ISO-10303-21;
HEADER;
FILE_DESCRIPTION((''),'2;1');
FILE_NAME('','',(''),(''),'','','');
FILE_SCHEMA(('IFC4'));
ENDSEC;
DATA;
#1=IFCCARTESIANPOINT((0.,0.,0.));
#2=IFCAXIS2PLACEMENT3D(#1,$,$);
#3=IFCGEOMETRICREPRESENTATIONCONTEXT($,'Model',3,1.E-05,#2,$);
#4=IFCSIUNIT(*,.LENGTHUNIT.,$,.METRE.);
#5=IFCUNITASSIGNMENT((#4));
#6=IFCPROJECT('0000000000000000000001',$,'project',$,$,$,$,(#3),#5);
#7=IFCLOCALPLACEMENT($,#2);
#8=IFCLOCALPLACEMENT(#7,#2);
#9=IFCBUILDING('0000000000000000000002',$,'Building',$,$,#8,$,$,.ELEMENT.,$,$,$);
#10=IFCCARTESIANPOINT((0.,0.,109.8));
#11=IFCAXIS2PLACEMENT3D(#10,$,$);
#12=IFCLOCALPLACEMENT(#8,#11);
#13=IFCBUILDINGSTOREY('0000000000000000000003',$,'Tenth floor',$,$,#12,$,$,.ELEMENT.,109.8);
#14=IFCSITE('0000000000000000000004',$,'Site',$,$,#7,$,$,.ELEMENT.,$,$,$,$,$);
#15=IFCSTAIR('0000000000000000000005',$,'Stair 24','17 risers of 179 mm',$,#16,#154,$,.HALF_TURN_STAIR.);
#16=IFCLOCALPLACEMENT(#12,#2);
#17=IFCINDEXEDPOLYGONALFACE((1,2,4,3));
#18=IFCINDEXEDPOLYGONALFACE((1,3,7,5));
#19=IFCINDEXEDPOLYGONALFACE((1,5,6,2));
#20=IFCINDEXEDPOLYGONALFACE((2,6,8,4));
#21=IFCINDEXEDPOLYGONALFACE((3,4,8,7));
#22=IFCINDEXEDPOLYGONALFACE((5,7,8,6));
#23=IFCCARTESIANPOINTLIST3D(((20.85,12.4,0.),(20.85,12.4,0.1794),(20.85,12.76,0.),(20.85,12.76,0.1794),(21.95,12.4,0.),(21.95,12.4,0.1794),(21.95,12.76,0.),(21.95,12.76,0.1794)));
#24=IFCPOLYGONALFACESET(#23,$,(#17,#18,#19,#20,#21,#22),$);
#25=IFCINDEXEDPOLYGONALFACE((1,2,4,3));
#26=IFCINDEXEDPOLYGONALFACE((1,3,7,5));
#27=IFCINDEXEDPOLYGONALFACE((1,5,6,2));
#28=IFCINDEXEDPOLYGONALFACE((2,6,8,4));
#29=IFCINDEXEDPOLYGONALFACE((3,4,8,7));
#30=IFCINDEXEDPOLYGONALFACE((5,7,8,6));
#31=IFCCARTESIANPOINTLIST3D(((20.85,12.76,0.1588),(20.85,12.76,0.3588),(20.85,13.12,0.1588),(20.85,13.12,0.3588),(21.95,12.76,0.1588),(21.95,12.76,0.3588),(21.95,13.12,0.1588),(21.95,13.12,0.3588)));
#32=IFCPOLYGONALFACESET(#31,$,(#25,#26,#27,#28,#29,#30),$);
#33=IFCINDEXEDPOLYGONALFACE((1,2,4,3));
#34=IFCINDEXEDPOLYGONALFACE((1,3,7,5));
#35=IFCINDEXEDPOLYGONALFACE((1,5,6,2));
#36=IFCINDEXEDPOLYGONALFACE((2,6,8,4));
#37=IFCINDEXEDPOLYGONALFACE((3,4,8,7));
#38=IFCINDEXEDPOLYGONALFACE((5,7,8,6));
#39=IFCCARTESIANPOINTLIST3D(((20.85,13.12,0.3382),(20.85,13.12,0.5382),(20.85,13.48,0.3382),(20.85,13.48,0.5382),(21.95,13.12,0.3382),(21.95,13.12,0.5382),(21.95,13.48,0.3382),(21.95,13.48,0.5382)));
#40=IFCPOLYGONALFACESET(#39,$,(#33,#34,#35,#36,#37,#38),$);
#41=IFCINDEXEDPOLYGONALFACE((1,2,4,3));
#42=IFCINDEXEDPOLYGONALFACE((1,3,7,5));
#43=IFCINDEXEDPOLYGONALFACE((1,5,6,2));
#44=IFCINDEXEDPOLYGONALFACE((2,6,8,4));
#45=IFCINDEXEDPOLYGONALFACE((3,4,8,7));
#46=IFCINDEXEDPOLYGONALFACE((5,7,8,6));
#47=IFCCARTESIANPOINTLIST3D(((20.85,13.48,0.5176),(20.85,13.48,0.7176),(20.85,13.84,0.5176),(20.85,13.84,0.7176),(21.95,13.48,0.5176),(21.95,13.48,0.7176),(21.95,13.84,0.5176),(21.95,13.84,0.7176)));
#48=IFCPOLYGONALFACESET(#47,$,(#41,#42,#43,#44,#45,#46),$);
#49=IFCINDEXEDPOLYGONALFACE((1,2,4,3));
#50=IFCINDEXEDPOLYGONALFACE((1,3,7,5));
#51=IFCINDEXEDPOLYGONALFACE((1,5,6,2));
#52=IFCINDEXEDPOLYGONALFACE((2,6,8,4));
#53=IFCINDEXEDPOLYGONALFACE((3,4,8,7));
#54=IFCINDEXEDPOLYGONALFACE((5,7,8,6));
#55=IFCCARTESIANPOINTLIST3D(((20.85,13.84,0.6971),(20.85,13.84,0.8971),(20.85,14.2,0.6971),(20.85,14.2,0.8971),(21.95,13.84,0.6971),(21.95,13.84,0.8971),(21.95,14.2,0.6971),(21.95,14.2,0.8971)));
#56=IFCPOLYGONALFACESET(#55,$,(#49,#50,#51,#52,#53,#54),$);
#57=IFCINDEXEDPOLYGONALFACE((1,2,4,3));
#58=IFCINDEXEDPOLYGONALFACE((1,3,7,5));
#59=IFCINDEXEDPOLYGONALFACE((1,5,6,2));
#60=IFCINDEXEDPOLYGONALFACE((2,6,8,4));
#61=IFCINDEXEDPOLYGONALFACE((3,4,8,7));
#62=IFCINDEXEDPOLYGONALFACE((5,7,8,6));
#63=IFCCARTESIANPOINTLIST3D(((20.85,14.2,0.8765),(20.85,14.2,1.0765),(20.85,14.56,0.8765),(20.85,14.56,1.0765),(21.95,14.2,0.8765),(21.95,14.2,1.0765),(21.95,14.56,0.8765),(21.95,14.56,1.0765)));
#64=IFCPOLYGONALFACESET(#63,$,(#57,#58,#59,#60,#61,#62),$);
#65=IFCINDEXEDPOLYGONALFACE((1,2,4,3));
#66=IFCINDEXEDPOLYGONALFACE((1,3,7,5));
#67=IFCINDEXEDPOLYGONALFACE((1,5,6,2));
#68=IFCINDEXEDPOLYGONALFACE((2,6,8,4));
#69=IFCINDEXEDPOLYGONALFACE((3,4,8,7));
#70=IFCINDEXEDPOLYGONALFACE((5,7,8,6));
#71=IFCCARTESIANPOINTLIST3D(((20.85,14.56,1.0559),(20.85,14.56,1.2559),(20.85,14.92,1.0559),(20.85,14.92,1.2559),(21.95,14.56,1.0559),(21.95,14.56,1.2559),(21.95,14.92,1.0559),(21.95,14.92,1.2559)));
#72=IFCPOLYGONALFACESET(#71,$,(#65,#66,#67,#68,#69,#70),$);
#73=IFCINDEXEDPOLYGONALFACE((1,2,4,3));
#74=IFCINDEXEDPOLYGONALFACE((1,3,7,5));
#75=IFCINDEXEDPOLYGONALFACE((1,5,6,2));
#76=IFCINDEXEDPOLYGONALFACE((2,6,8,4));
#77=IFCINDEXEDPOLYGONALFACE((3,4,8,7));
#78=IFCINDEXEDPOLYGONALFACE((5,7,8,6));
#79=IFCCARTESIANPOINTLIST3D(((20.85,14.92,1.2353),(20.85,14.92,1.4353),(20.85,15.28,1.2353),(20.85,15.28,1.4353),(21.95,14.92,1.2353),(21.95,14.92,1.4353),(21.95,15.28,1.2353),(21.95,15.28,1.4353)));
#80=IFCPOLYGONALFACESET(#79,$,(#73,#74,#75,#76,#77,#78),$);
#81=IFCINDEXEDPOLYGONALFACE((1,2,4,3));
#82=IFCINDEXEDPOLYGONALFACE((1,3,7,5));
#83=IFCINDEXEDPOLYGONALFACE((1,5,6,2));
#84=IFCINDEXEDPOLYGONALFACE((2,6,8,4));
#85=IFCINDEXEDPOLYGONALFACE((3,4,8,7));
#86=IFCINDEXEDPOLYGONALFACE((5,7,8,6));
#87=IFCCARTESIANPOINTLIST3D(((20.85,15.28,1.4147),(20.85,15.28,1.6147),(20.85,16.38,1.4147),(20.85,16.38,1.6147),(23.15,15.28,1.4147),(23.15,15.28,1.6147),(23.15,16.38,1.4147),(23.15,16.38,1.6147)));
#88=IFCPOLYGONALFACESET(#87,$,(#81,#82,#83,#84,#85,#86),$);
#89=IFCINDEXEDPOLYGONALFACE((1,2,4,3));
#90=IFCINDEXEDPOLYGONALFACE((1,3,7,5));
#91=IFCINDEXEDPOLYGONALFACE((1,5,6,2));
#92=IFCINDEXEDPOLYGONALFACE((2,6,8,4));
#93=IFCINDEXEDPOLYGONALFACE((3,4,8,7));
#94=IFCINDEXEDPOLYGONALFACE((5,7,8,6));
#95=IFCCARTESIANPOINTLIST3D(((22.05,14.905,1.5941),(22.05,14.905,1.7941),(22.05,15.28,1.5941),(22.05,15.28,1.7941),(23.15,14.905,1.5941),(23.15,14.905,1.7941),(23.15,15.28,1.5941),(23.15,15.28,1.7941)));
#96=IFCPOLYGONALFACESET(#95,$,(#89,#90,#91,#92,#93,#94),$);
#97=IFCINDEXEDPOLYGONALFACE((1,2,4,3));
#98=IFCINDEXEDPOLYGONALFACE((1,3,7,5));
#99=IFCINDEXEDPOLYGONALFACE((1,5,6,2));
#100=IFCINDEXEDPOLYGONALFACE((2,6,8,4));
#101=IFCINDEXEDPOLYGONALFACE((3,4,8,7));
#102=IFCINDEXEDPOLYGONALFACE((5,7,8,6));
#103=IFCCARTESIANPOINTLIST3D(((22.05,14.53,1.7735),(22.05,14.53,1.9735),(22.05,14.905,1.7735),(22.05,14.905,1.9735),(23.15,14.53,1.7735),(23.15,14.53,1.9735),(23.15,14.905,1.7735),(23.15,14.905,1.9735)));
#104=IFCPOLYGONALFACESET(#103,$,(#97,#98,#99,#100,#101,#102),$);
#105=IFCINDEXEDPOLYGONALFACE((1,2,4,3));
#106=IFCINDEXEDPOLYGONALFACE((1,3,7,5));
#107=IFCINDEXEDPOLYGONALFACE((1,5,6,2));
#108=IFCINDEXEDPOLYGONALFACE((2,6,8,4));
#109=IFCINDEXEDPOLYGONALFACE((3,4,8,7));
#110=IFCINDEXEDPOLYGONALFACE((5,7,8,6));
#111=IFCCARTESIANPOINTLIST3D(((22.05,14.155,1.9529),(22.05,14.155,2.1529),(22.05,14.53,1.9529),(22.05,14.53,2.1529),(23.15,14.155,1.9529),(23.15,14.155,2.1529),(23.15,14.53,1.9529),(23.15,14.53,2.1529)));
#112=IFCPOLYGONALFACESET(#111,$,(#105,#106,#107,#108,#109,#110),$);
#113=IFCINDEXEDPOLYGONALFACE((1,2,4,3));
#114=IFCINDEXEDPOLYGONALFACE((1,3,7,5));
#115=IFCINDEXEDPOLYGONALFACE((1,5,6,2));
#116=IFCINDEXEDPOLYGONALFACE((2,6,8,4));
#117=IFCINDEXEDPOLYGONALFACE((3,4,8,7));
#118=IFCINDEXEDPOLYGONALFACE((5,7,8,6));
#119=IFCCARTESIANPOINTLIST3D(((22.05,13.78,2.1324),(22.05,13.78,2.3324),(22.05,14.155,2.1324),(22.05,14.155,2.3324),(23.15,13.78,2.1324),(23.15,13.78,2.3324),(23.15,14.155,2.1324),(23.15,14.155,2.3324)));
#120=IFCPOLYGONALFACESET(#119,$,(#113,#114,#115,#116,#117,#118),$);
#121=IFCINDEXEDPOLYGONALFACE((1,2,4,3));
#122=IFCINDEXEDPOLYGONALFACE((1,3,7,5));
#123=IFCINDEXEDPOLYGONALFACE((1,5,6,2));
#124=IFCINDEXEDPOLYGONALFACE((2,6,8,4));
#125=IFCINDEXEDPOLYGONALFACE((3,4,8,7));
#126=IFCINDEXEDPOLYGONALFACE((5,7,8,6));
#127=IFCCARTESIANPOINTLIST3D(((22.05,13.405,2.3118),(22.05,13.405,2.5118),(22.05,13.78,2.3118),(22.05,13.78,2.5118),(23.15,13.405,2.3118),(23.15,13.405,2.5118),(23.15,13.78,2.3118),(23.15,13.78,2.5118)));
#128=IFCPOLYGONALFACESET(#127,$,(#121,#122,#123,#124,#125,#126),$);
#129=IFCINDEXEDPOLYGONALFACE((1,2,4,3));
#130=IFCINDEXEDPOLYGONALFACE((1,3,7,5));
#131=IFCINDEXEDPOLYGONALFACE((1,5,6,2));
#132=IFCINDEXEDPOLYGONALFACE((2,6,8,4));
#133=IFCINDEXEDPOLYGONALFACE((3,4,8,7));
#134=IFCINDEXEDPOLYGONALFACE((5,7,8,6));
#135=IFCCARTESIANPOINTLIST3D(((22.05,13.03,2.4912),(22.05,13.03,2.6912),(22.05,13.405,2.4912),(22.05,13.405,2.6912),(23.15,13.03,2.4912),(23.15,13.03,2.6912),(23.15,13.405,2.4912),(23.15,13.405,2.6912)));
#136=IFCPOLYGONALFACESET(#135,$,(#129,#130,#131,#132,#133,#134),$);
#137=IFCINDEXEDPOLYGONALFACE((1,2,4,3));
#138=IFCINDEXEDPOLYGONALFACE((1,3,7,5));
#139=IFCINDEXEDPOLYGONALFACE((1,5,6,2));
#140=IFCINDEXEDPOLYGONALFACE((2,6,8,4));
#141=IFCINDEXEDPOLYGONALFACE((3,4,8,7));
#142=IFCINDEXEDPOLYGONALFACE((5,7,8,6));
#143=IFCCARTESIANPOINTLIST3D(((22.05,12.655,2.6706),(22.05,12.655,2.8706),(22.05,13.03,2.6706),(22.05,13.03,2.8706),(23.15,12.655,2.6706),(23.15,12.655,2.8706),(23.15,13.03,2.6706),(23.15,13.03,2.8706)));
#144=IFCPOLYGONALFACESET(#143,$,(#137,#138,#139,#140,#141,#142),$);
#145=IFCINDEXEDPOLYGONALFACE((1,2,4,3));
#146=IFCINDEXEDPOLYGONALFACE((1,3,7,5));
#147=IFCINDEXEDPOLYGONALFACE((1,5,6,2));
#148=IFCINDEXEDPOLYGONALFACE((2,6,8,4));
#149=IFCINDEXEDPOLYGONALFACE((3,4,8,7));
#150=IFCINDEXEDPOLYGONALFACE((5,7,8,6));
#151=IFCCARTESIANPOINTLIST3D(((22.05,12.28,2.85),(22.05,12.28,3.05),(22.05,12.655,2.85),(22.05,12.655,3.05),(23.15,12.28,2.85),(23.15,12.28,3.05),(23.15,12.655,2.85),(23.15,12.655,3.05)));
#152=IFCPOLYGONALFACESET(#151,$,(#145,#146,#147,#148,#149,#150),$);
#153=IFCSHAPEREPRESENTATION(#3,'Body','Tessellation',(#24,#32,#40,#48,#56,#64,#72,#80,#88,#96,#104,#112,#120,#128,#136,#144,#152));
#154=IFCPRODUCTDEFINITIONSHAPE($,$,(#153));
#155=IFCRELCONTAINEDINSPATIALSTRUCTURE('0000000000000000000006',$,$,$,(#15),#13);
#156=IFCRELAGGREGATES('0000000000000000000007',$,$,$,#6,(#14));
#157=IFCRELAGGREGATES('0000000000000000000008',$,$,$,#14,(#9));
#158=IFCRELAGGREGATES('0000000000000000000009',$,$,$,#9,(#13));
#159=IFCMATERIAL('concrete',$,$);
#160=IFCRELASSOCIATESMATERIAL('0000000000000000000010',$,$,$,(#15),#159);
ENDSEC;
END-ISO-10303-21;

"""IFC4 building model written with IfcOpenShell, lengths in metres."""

from ifc_helpers import new_model, si_unit, frame, origin, place, context, project, spatial, polyline, outline, extrude, material, element, save


model = new_model("IFC4")

# Units and contexts
model_context = context("Model", 3, precision=1e-05, world=origin())
ifc_project = project(units=[si_unit("LENGTHUNIT", "METRE")], contexts=[model_context])

# Site, building, storey
site_placement = place(None, origin())
site = spatial("IfcSite", under=ifc_project, at=site_placement, Name="Site", CompositionType="ELEMENT")
building_placement = place(site_placement, origin())
building = spatial("IfcBuilding", under=site, at=building_placement, Name="Building", CompositionType="ELEMENT")
storey_placement = place(building_placement, frame((0.0, 0.0, 109.8)))
storey = spatial("IfcBuildingStorey", under=building, at=storey_placement, Name="Tenth floor", CompositionType="ELEMENT", Elevation=109.8)

# Shared definitions
ifc_material = material(Name="concrete")

# Stair
stair_1_placement = place(storey_placement, frame((21.4, 12.4, 0.0), z_axis=(0.0, 0.0, 1.0), x_axis=(0.0, 1.0, 0.0)))
element("IfcStair", 1, at=stair_1_placement, inside=storey, material=ifc_material, Name="Stair 24", Description="17 risers of 179 mm", PredefinedType="HALF_TURN_STAIR", context=model_context, shape_type="SweptSolid", body=[
    extrude(outline(polyline([(0.0, -0.55), (0.36, -0.55), (0.36, 0.55), (0.0, 0.55), (0.0, -0.55)])), origin(), (0.0, 0.0, 1.0), 0.1794),
    extrude(outline(polyline([(0.36, -0.55), (0.72, -0.55), (0.72, 0.55), (0.36, 0.55), (0.36, -0.55)])), frame((0.0, 0.0, 0.1588)), (0.0, 0.0, 1.0), 0.2),
    extrude(outline(polyline([(0.72, -0.55), (1.08, -0.55), (1.08, 0.55), (0.72, 0.55), (0.72, -0.55)])), frame((0.0, 0.0, 0.3382)), (0.0, 0.0, 1.0), 0.2),
    extrude(outline(polyline([(1.08, -0.55), (1.44, -0.55), (1.44, 0.55), (1.08, 0.55), (1.08, -0.55)])), frame((0.0, 0.0, 0.5176)), (0.0, 0.0, 1.0), 0.2),
    extrude(outline(polyline([(1.44, -0.55), (1.8, -0.55), (1.8, 0.55), (1.44, 0.55), (1.44, -0.55)])), frame((0.0, 0.0, 0.6971)), (0.0, 0.0, 1.0), 0.2),
    extrude(outline(polyline([(1.8, -0.55), (2.16, -0.55), (2.16, 0.55), (1.8, 0.55), (1.8, -0.55)])), frame((0.0, 0.0, 0.8765)), (0.0, 0.0, 1.0), 0.2),
    extrude(outline(polyline([(2.16, -0.55), (2.52, -0.55), (2.52, 0.55), (2.16, 0.55), (2.16, -0.55)])), frame((0.0, 0.0, 1.0559)), (0.0, 0.0, 1.0), 0.2),
    extrude(outline(polyline([(2.52, -0.55), (2.88, -0.55), (2.88, 0.55), (2.52, 0.55), (2.52, -0.55)])), frame((0.0, 0.0, 1.2353)), (0.0, 0.0, 1.0), 0.2),
    extrude(outline(polyline([(2.88, -1.75), (3.98, -1.75), (3.98, 0.55), (2.88, 0.55), (2.88, -1.75)])), frame((0.0, 0.0, 1.4147)), (0.0, 0.0, 1.0), 0.2),
    extrude(outline(polyline([(2.505, -1.75), (2.88, -1.75), (2.88, -0.65), (2.505, -0.65), (2.505, -1.75)])), frame((0.0, 0.0, 1.5941)), (0.0, 0.0, 1.0), 0.2),
    extrude(outline(polyline([(2.13, -1.75), (2.505, -1.75), (2.505, -0.65), (2.13, -0.65), (2.13, -1.75)])), frame((0.0, 0.0, 1.7735)), (0.0, 0.0, 1.0), 0.2),
    extrude(outline(polyline([(1.755, -1.75), (2.13, -1.75), (2.13, -0.65), (1.755, -0.65), (1.755, -1.75)])), frame((0.0, 0.0, 1.9529)), (0.0, 0.0, 1.0), 0.2),
    extrude(outline(polyline([(1.38, -1.75), (1.755, -1.75), (1.755, -0.65), (1.38, -0.65), (1.38, -1.75)])), frame((0.0, 0.0, 2.1324)), (0.0, 0.0, 1.0), 0.2),
    extrude(outline(polyline([(1.005, -1.75), (1.38, -1.75), (1.38, -0.65), (1.005, -0.65), (1.005, -1.75)])), frame((0.0, 0.0, 2.3118)), (0.0, 0.0, 1.0), 0.2),
    extrude(outline(polyline([(0.63, -1.75), (1.005, -1.75), (1.005, -0.65), (0.63, -0.65), (0.63, -1.75)])), frame((0.0, 0.0, 2.4912)), (0.0, 0.0, 1.0), 0.2),
    extrude(outline(polyline([(0.255, -1.75), (0.63, -1.75), (0.63, -0.65), (0.255, -0.65), (0.255, -1.75)])), frame((0.0, 0.0, 2.6706)), (0.0, 0.0, 1.0), 0.2),
    extrude(outline(polyline([(-0.12, -1.75), (0.255, -1.75), (0.255, -0.65), (-0.12, -0.65), (-0.12, -1.75)])), frame((0.0, 0.0, 2.85)), (0.0, 0.0, 1.0), 0.2),
])

save(model, "model.ifc")
